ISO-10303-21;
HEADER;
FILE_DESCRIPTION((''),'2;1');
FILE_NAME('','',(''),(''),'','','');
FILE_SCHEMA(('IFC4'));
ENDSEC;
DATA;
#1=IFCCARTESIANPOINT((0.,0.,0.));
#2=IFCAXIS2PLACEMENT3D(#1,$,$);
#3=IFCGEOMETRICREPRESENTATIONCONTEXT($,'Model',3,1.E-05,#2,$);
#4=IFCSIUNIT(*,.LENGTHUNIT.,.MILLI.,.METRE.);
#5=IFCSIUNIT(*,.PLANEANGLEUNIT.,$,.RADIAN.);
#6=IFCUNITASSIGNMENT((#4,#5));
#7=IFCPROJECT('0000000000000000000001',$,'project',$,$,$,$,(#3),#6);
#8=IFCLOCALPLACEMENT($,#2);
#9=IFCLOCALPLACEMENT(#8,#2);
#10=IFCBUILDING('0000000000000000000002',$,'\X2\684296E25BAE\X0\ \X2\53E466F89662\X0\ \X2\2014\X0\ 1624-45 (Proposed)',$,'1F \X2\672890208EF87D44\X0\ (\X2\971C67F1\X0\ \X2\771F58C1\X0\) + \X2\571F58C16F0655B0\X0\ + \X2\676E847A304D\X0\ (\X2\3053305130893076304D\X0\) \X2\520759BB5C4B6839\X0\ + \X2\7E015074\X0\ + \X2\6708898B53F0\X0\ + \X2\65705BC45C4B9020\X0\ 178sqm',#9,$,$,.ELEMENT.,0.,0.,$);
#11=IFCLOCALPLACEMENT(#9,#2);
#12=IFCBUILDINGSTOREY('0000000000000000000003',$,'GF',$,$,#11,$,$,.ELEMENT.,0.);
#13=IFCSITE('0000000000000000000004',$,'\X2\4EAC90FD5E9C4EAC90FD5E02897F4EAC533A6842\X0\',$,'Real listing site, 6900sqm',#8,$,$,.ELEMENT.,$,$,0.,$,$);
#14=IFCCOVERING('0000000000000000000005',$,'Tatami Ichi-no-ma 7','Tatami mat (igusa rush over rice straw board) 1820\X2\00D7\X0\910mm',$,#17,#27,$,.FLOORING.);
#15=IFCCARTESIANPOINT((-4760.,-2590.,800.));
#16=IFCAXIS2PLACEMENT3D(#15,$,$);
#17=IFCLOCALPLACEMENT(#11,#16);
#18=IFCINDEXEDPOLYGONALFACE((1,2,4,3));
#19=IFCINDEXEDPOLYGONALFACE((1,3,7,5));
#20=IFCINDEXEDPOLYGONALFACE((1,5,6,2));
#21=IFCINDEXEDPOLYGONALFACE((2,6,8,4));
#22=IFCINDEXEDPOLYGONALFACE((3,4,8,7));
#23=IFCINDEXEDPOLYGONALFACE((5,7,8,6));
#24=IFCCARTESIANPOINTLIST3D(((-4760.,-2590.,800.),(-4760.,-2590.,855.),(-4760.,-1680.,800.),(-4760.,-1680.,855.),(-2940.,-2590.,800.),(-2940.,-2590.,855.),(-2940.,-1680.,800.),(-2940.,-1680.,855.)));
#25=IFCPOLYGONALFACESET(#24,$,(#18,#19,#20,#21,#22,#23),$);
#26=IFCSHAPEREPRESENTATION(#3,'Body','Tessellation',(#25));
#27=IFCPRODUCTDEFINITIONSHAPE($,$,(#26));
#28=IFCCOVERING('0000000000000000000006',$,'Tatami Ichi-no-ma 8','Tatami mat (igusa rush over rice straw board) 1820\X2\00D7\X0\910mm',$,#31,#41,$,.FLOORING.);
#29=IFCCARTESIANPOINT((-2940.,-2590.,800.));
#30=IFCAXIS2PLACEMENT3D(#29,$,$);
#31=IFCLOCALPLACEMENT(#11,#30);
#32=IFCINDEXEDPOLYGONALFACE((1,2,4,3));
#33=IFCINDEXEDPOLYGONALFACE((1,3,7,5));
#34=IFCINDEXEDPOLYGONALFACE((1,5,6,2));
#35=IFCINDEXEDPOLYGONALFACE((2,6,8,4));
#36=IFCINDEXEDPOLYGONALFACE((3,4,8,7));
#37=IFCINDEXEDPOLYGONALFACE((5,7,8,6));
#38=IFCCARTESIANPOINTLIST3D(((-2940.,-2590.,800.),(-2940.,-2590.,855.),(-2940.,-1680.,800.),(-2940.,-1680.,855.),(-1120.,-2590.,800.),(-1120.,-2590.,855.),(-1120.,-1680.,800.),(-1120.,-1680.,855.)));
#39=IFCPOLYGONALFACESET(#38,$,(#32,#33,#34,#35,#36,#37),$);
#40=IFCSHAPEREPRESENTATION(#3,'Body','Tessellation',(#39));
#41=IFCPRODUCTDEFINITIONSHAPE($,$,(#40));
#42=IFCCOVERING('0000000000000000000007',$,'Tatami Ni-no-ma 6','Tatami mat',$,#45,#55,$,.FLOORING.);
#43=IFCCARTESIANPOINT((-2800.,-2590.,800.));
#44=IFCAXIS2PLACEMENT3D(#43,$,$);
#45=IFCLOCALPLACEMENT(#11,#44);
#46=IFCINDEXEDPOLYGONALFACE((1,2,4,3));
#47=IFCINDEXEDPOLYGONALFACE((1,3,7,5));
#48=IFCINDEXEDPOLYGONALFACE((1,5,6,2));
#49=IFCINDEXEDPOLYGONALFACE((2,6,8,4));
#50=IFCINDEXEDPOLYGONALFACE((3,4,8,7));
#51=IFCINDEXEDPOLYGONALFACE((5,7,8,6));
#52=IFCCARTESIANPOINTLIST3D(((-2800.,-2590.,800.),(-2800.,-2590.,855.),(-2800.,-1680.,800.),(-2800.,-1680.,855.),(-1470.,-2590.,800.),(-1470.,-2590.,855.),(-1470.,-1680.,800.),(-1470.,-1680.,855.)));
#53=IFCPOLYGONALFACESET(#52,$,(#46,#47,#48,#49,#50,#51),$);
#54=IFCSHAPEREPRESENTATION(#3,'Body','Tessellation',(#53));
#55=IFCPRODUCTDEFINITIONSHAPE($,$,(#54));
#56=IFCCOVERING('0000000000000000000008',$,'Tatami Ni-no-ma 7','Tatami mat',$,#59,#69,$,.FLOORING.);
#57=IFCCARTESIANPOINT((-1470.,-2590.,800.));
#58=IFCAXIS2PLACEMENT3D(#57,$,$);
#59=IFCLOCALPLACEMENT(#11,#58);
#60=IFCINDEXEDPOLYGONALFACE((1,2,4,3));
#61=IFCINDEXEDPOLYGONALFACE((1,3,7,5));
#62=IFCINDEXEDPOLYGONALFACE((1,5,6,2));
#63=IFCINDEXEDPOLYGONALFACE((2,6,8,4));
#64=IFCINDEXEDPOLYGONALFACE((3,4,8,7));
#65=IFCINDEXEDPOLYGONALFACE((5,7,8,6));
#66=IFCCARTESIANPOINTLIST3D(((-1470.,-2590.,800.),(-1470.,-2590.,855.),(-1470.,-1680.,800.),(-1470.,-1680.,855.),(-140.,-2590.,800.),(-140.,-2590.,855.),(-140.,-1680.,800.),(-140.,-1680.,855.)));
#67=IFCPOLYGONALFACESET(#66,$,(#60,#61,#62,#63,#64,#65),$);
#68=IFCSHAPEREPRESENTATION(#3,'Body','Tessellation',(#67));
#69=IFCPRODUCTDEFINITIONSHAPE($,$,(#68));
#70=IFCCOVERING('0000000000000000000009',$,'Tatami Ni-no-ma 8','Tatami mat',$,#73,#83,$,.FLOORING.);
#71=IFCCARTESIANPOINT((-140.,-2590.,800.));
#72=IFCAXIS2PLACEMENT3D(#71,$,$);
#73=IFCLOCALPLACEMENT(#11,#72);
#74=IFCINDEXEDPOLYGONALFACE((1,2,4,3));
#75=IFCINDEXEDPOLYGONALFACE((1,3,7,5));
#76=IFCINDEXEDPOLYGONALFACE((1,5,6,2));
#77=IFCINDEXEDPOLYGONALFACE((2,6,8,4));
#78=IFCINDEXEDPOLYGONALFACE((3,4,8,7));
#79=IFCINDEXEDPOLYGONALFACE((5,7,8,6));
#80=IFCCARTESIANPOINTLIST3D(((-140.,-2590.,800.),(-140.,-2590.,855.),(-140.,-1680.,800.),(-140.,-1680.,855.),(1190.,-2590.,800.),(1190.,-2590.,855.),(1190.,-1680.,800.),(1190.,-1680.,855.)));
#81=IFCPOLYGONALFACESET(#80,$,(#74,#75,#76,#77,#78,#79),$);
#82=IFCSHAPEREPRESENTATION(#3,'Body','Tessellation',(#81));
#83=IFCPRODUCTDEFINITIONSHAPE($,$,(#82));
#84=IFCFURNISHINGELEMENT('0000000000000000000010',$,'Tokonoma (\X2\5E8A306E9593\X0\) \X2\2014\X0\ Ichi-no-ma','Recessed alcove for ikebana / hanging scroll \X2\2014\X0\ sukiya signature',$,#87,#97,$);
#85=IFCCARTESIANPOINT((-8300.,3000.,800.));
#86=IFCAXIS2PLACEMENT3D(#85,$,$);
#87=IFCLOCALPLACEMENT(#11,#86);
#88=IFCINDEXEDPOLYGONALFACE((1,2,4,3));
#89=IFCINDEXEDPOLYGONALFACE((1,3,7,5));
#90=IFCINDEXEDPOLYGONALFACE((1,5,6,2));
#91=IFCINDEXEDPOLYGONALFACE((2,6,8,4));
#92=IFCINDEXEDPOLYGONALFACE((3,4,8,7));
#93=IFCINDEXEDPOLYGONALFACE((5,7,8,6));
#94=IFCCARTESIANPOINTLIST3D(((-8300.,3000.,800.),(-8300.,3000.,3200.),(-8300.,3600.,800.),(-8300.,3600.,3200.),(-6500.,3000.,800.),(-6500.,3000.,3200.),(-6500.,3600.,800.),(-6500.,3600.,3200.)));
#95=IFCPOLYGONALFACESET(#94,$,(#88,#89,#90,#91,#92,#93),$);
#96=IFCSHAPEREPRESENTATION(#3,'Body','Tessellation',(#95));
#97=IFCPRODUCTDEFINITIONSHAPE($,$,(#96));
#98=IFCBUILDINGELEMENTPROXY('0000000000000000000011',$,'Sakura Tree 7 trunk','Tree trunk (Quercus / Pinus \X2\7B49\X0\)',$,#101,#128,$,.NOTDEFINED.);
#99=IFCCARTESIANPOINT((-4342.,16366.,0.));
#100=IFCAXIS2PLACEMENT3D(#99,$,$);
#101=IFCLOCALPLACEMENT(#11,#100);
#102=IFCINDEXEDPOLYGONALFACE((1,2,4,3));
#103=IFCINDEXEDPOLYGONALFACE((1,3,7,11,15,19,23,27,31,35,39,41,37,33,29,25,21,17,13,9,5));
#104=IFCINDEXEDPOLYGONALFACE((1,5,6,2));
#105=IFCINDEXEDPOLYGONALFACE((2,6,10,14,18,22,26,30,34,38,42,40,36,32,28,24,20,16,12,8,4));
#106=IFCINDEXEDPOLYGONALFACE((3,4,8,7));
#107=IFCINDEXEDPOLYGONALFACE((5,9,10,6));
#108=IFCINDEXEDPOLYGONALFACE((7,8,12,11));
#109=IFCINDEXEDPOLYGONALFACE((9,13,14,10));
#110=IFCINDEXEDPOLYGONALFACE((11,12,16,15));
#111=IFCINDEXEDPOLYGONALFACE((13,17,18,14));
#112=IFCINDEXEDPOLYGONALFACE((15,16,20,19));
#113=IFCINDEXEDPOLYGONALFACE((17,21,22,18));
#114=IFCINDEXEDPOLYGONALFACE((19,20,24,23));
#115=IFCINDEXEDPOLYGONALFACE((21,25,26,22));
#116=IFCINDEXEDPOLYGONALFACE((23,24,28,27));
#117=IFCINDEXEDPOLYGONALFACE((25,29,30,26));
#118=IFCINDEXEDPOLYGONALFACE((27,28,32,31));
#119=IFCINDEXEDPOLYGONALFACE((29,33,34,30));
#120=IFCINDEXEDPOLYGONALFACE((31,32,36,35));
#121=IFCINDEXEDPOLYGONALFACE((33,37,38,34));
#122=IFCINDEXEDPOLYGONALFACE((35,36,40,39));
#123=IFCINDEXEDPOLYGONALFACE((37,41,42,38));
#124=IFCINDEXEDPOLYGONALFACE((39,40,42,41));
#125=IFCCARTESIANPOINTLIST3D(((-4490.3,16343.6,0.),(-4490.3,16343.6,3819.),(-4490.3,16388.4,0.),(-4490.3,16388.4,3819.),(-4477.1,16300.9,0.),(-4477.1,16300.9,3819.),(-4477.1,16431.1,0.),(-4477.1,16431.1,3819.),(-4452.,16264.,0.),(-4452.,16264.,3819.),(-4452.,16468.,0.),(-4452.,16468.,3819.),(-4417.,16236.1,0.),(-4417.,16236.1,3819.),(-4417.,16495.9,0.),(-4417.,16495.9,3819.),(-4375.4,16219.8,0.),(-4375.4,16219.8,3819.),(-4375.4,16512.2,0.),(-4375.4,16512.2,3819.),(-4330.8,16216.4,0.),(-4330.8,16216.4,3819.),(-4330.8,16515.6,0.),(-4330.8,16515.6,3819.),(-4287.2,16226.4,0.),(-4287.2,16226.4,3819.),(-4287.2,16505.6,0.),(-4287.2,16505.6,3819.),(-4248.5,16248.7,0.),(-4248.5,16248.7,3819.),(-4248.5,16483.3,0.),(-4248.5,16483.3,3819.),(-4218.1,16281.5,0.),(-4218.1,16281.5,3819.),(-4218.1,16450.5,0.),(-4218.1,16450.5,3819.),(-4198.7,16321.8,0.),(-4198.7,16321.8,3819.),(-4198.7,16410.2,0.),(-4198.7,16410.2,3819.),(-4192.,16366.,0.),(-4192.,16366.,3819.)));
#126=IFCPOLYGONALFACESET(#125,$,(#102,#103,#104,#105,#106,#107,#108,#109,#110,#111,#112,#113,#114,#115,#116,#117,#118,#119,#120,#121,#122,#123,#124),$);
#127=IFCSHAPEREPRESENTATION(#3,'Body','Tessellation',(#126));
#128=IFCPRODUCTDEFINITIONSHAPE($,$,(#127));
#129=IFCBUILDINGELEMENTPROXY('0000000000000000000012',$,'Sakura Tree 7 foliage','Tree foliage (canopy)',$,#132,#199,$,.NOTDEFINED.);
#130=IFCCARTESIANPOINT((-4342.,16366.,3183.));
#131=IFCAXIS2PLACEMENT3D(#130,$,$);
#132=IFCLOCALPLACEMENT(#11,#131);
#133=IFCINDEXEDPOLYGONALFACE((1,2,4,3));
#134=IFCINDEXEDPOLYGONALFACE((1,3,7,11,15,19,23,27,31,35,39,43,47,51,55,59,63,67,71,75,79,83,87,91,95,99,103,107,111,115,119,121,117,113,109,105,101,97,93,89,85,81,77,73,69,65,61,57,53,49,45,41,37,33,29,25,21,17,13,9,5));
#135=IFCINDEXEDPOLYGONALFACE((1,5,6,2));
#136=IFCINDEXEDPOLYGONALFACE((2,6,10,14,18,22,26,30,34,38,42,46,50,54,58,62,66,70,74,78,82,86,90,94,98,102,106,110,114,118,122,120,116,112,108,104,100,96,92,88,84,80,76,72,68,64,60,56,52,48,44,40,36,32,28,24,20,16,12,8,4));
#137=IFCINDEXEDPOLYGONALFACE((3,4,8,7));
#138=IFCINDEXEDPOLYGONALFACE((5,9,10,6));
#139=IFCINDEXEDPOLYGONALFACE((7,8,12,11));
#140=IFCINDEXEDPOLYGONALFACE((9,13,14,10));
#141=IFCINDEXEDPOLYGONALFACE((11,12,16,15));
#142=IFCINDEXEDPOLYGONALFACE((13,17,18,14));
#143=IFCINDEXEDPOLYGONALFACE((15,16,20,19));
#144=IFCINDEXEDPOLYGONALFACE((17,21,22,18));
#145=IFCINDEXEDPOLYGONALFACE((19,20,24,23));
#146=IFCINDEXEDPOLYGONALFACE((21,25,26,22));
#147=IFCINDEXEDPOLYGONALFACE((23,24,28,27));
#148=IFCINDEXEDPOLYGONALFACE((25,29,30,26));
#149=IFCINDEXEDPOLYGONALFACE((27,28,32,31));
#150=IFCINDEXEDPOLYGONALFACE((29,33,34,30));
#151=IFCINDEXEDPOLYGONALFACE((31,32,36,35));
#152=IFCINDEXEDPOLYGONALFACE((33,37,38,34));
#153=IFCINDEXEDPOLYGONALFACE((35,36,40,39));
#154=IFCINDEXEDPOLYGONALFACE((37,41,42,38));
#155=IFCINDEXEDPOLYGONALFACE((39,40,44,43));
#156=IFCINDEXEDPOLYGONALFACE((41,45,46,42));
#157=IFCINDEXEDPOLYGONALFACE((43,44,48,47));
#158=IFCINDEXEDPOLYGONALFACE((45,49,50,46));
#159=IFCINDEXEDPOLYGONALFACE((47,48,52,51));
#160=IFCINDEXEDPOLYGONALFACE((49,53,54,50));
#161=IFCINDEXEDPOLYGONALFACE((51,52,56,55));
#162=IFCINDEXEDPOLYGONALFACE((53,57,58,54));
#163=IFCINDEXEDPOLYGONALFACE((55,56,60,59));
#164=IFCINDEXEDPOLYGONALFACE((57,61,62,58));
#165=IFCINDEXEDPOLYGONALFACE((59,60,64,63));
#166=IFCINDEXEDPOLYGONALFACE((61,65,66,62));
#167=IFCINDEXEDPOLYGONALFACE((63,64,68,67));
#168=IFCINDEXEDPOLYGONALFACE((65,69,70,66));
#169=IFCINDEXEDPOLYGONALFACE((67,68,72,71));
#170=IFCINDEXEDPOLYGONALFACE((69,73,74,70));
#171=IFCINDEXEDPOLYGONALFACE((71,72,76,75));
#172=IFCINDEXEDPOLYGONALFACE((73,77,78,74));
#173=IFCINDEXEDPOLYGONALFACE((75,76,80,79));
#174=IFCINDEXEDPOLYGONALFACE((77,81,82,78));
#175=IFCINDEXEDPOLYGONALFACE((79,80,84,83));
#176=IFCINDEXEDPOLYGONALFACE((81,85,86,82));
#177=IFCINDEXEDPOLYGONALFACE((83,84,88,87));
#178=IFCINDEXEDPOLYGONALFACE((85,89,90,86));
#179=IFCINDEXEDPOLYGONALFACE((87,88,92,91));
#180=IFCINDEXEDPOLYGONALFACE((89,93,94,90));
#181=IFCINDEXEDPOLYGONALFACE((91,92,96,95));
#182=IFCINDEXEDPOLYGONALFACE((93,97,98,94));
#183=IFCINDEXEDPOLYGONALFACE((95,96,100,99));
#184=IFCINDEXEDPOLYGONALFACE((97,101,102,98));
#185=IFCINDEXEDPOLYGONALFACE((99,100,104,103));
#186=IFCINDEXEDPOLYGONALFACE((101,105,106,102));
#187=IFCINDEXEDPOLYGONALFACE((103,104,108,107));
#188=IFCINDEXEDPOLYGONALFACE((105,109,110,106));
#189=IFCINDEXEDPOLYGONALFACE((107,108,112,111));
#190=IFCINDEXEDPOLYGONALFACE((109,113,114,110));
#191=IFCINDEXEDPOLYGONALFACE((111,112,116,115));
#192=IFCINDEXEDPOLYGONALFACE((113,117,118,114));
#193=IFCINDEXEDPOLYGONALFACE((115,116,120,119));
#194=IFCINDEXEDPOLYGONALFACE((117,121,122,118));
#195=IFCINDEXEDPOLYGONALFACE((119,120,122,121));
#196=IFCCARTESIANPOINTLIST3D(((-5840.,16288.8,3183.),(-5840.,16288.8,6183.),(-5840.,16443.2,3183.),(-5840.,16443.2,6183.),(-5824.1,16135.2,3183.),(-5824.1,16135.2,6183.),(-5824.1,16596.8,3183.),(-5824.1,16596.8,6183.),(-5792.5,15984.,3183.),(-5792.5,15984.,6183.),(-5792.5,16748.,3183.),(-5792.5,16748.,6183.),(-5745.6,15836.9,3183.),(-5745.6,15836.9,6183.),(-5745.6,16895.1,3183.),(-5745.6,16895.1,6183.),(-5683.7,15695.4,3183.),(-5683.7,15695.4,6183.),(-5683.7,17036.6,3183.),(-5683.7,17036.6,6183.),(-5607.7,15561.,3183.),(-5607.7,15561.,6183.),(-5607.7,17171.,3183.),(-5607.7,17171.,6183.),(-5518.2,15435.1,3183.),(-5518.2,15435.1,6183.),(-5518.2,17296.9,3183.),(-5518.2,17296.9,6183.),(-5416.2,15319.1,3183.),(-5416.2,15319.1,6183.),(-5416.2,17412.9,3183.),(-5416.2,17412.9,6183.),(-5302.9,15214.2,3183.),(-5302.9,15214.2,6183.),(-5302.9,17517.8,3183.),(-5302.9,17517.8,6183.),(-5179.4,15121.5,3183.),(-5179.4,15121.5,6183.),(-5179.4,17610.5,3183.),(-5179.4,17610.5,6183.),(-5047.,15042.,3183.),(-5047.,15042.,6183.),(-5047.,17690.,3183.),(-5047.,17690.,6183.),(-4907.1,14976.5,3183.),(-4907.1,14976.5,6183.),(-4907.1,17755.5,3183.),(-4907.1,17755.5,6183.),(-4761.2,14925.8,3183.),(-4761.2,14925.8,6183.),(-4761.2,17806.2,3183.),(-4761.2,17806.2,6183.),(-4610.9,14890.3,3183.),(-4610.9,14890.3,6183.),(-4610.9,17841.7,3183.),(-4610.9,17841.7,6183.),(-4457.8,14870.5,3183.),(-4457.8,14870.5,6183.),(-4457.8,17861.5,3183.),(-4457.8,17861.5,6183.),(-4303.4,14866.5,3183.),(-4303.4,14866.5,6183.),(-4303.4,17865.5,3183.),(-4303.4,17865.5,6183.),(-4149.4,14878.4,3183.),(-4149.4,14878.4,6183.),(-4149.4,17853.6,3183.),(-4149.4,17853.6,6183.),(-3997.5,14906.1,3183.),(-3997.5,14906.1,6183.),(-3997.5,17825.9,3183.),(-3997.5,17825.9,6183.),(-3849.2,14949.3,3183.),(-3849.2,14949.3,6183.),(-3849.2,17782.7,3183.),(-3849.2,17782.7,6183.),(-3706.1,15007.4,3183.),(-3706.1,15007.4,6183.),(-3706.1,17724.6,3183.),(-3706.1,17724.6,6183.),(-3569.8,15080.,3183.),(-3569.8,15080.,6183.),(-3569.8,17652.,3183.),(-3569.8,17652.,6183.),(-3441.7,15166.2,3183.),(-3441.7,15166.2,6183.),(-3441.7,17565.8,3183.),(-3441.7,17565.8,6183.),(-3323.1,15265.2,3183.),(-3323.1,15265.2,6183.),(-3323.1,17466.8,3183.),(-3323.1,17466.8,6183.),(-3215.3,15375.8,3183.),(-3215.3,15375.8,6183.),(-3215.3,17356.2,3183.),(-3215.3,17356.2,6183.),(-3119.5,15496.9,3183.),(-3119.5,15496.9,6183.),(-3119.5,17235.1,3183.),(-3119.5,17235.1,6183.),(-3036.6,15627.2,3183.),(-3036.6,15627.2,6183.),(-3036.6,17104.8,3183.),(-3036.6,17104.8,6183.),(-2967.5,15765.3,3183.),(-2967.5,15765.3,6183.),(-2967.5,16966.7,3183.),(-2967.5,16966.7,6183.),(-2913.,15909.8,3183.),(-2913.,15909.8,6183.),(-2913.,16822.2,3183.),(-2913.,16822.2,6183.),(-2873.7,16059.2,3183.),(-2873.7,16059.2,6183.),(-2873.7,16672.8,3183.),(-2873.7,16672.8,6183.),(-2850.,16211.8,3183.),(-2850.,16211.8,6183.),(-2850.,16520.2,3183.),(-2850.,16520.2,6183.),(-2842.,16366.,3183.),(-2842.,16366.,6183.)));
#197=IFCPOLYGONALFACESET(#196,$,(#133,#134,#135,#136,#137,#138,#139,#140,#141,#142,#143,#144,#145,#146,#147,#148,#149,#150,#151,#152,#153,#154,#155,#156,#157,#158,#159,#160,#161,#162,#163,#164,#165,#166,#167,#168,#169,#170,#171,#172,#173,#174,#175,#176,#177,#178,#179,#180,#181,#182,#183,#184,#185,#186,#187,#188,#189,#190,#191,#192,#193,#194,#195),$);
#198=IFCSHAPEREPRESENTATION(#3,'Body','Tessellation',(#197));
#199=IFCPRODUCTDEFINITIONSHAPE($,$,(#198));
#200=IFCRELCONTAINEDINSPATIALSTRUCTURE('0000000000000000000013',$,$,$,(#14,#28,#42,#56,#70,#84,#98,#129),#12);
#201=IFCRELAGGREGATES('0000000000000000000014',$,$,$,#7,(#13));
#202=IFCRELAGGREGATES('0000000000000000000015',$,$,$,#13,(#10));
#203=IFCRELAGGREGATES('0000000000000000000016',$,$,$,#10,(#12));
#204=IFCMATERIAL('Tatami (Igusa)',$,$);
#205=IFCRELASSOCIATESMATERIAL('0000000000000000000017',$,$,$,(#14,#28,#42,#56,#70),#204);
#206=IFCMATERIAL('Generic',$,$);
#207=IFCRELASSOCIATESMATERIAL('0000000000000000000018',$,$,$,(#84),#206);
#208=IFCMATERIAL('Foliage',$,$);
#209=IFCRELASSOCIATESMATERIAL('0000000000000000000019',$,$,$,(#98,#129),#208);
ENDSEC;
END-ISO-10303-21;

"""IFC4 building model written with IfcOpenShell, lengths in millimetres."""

from ifc_helpers import new_model, si_unit, frame, frame_2d, origin, origin_2d, place, context, project, spatial, rectangle, circle, extrude, material, element, save


model = new_model("IFC4")

# Units and contexts
model_context = context("Model", 3, precision=1e-05, world=origin())
ifc_project = project(units=[si_unit("LENGTHUNIT", "METRE", prefix="MILLI"), si_unit("PLANEANGLEUNIT", "RADIAN")], contexts=[model_context])

# Site, building, storey
site_placement = place(None, origin())
site = spatial("IfcSite", under=ifc_project, at=site_placement, Name="京都府京都市西京区桂", ObjectType="Real listing site, 6900sqm", CompositionType="ELEMENT", RefElevation=0.0)
building_placement = place(site_placement, origin())
building = spatial("IfcBuilding", under=site, at=building_placement, Name="桂離宮 古書院 — 1624-45 (Proposed)", ObjectType="1F 木造軸組 (霜柱 真壁) + 土壁漆喰 + 杮葺き (こけらぶき) 切妻屋根 + 縁側 + 月見台 + 数寄屋造 178sqm", CompositionType="ELEMENT", ElevationOfRefHeight=0.0, ElevationOfTerrain=0.0)
storey_placement = place(building_placement, origin())
storey = spatial("IfcBuildingStorey", under=building, at=storey_placement, Name="GF", CompositionType="ELEMENT", Elevation=0.0)

# Coverings
ifc_material_1 = material(Name="Tatami (Igusa)")
covering_1_placement = place(storey_placement, frame((-4760.0, -2590.0, 800.0)))
element("IfcCovering", 1, at=covering_1_placement, inside=storey, material=ifc_material_1, Name="Tatami Ichi-no-ma 7", Description="Tatami mat (igusa rush over rice straw board) 1820×910mm", PredefinedType="FLOORING", context=model_context, shape_type="SweptSolid", body=[
    extrude(rectangle(XDim=1820.0, YDim=910.0, at=frame_2d((910.0, 455.0))), frame((-4760.0, -2590.0, 800.0)), (0.0, 0.0, 1.0), 55.0),
])
covering_2_placement = place(storey_placement, frame((-2940.0, -2590.0, 800.0)))
element("IfcCovering", 2, at=covering_2_placement, inside=storey, material=ifc_material_1, Name="Tatami Ichi-no-ma 8", Description="Tatami mat (igusa rush over rice straw board) 1820×910mm", PredefinedType="FLOORING", context=model_context, shape_type="SweptSolid", body=[
    extrude(rectangle(XDim=1820.0, YDim=910.0, at=frame_2d((910.0, 455.0))), frame((-2940.0, -2590.0, 800.0)), (0.0, 0.0, 1.0), 55.0),
])
covering_3_placement = place(storey_placement, frame((-2800.0, -2590.0, 800.0)))
element("IfcCovering", 3, at=covering_3_placement, inside=storey, material=ifc_material_1, Name="Tatami Ni-no-ma 6", Description="Tatami mat", PredefinedType="FLOORING", context=model_context, shape_type="SweptSolid", body=[
    extrude(rectangle(XDim=1330.0, YDim=910.0, at=frame_2d((665.0, 455.0))), frame((-2800.0, -2590.0, 800.0)), (0.0, 0.0, 1.0), 55.0),
])
covering_4_placement = place(storey_placement, frame((-1470.0, -2590.0, 800.0)))
element("IfcCovering", 4, at=covering_4_placement, inside=storey, material=ifc_material_1, Name="Tatami Ni-no-ma 7", Description="Tatami mat", PredefinedType="FLOORING", context=model_context, shape_type="SweptSolid", body=[
    extrude(rectangle(XDim=1330.0, YDim=910.0, at=frame_2d((665.0, 455.0))), frame((-1470.0, -2590.0, 800.0)), (0.0, 0.0, 1.0), 55.0),
])
covering_5_placement = place(storey_placement, frame((-140.0, -2590.0, 800.0)))
element("IfcCovering", 5, at=covering_5_placement, inside=storey, material=ifc_material_1, Name="Tatami Ni-no-ma 8", Description="Tatami mat", PredefinedType="FLOORING", context=model_context, shape_type="SweptSolid", body=[
    extrude(rectangle(XDim=1330.0, YDim=910.0, at=frame_2d((665.0, 455.0))), frame((-140.0, -2590.0, 800.0)), (0.0, 0.0, 1.0), 55.0),
])

# Furnishing element
ifc_material_2 = material(Name="Generic")
furnishing_placement = place(storey_placement, frame((-8300.0, 3000.0, 800.0)))
element("IfcFurnishingElement", 6, at=furnishing_placement, inside=storey, material=ifc_material_2, Name="Tokonoma (床の間) — Ichi-no-ma", Description="Recessed alcove for ikebana / hanging scroll — sukiya signature", context=model_context, shape_type="SweptSolid", body=[
    extrude(rectangle(XDim=1800.0, YDim=600.0, at=frame_2d((900.0, 300.0))), frame((-8300.0, 3000.0, 800.0)), (0.0, 0.0, 1.0), 2400.0),
])

# Building element proxies
ifc_material_3 = material(Name="Foliage")
proxy_1_placement = place(storey_placement, frame((-4342.0, 16366.0, 0.0)))
element("IfcBuildingElementProxy", 7, at=proxy_1_placement, inside=storey, material=ifc_material_3, Name="Sakura Tree 7 trunk", Description="Tree trunk (Quercus / Pinus 等)", PredefinedType="NOTDEFINED", context=model_context, shape_type="SweptSolid", body=[
    extrude(circle(Radius=150.0, at=origin_2d()), frame((-4342.0, 16366.0, 0.0)), (0.0, 0.0, 1.0), 3819.0),
])
proxy_2_placement = place(storey_placement, frame((-4342.0, 16366.0, 3183.0)))
element("IfcBuildingElementProxy", 8, at=proxy_2_placement, inside=storey, material=ifc_material_3, Name="Sakura Tree 7 foliage", Description="Tree foliage (canopy)", PredefinedType="NOTDEFINED", context=model_context, shape_type="SweptSolid", body=[
    extrude(circle(Radius=1500.0, at=origin_2d()), frame((-4342.0, 16366.0, 3183.0)), (0.0, 0.0, 1.0), 3000.0),
])

save(model, "model.ifc")
